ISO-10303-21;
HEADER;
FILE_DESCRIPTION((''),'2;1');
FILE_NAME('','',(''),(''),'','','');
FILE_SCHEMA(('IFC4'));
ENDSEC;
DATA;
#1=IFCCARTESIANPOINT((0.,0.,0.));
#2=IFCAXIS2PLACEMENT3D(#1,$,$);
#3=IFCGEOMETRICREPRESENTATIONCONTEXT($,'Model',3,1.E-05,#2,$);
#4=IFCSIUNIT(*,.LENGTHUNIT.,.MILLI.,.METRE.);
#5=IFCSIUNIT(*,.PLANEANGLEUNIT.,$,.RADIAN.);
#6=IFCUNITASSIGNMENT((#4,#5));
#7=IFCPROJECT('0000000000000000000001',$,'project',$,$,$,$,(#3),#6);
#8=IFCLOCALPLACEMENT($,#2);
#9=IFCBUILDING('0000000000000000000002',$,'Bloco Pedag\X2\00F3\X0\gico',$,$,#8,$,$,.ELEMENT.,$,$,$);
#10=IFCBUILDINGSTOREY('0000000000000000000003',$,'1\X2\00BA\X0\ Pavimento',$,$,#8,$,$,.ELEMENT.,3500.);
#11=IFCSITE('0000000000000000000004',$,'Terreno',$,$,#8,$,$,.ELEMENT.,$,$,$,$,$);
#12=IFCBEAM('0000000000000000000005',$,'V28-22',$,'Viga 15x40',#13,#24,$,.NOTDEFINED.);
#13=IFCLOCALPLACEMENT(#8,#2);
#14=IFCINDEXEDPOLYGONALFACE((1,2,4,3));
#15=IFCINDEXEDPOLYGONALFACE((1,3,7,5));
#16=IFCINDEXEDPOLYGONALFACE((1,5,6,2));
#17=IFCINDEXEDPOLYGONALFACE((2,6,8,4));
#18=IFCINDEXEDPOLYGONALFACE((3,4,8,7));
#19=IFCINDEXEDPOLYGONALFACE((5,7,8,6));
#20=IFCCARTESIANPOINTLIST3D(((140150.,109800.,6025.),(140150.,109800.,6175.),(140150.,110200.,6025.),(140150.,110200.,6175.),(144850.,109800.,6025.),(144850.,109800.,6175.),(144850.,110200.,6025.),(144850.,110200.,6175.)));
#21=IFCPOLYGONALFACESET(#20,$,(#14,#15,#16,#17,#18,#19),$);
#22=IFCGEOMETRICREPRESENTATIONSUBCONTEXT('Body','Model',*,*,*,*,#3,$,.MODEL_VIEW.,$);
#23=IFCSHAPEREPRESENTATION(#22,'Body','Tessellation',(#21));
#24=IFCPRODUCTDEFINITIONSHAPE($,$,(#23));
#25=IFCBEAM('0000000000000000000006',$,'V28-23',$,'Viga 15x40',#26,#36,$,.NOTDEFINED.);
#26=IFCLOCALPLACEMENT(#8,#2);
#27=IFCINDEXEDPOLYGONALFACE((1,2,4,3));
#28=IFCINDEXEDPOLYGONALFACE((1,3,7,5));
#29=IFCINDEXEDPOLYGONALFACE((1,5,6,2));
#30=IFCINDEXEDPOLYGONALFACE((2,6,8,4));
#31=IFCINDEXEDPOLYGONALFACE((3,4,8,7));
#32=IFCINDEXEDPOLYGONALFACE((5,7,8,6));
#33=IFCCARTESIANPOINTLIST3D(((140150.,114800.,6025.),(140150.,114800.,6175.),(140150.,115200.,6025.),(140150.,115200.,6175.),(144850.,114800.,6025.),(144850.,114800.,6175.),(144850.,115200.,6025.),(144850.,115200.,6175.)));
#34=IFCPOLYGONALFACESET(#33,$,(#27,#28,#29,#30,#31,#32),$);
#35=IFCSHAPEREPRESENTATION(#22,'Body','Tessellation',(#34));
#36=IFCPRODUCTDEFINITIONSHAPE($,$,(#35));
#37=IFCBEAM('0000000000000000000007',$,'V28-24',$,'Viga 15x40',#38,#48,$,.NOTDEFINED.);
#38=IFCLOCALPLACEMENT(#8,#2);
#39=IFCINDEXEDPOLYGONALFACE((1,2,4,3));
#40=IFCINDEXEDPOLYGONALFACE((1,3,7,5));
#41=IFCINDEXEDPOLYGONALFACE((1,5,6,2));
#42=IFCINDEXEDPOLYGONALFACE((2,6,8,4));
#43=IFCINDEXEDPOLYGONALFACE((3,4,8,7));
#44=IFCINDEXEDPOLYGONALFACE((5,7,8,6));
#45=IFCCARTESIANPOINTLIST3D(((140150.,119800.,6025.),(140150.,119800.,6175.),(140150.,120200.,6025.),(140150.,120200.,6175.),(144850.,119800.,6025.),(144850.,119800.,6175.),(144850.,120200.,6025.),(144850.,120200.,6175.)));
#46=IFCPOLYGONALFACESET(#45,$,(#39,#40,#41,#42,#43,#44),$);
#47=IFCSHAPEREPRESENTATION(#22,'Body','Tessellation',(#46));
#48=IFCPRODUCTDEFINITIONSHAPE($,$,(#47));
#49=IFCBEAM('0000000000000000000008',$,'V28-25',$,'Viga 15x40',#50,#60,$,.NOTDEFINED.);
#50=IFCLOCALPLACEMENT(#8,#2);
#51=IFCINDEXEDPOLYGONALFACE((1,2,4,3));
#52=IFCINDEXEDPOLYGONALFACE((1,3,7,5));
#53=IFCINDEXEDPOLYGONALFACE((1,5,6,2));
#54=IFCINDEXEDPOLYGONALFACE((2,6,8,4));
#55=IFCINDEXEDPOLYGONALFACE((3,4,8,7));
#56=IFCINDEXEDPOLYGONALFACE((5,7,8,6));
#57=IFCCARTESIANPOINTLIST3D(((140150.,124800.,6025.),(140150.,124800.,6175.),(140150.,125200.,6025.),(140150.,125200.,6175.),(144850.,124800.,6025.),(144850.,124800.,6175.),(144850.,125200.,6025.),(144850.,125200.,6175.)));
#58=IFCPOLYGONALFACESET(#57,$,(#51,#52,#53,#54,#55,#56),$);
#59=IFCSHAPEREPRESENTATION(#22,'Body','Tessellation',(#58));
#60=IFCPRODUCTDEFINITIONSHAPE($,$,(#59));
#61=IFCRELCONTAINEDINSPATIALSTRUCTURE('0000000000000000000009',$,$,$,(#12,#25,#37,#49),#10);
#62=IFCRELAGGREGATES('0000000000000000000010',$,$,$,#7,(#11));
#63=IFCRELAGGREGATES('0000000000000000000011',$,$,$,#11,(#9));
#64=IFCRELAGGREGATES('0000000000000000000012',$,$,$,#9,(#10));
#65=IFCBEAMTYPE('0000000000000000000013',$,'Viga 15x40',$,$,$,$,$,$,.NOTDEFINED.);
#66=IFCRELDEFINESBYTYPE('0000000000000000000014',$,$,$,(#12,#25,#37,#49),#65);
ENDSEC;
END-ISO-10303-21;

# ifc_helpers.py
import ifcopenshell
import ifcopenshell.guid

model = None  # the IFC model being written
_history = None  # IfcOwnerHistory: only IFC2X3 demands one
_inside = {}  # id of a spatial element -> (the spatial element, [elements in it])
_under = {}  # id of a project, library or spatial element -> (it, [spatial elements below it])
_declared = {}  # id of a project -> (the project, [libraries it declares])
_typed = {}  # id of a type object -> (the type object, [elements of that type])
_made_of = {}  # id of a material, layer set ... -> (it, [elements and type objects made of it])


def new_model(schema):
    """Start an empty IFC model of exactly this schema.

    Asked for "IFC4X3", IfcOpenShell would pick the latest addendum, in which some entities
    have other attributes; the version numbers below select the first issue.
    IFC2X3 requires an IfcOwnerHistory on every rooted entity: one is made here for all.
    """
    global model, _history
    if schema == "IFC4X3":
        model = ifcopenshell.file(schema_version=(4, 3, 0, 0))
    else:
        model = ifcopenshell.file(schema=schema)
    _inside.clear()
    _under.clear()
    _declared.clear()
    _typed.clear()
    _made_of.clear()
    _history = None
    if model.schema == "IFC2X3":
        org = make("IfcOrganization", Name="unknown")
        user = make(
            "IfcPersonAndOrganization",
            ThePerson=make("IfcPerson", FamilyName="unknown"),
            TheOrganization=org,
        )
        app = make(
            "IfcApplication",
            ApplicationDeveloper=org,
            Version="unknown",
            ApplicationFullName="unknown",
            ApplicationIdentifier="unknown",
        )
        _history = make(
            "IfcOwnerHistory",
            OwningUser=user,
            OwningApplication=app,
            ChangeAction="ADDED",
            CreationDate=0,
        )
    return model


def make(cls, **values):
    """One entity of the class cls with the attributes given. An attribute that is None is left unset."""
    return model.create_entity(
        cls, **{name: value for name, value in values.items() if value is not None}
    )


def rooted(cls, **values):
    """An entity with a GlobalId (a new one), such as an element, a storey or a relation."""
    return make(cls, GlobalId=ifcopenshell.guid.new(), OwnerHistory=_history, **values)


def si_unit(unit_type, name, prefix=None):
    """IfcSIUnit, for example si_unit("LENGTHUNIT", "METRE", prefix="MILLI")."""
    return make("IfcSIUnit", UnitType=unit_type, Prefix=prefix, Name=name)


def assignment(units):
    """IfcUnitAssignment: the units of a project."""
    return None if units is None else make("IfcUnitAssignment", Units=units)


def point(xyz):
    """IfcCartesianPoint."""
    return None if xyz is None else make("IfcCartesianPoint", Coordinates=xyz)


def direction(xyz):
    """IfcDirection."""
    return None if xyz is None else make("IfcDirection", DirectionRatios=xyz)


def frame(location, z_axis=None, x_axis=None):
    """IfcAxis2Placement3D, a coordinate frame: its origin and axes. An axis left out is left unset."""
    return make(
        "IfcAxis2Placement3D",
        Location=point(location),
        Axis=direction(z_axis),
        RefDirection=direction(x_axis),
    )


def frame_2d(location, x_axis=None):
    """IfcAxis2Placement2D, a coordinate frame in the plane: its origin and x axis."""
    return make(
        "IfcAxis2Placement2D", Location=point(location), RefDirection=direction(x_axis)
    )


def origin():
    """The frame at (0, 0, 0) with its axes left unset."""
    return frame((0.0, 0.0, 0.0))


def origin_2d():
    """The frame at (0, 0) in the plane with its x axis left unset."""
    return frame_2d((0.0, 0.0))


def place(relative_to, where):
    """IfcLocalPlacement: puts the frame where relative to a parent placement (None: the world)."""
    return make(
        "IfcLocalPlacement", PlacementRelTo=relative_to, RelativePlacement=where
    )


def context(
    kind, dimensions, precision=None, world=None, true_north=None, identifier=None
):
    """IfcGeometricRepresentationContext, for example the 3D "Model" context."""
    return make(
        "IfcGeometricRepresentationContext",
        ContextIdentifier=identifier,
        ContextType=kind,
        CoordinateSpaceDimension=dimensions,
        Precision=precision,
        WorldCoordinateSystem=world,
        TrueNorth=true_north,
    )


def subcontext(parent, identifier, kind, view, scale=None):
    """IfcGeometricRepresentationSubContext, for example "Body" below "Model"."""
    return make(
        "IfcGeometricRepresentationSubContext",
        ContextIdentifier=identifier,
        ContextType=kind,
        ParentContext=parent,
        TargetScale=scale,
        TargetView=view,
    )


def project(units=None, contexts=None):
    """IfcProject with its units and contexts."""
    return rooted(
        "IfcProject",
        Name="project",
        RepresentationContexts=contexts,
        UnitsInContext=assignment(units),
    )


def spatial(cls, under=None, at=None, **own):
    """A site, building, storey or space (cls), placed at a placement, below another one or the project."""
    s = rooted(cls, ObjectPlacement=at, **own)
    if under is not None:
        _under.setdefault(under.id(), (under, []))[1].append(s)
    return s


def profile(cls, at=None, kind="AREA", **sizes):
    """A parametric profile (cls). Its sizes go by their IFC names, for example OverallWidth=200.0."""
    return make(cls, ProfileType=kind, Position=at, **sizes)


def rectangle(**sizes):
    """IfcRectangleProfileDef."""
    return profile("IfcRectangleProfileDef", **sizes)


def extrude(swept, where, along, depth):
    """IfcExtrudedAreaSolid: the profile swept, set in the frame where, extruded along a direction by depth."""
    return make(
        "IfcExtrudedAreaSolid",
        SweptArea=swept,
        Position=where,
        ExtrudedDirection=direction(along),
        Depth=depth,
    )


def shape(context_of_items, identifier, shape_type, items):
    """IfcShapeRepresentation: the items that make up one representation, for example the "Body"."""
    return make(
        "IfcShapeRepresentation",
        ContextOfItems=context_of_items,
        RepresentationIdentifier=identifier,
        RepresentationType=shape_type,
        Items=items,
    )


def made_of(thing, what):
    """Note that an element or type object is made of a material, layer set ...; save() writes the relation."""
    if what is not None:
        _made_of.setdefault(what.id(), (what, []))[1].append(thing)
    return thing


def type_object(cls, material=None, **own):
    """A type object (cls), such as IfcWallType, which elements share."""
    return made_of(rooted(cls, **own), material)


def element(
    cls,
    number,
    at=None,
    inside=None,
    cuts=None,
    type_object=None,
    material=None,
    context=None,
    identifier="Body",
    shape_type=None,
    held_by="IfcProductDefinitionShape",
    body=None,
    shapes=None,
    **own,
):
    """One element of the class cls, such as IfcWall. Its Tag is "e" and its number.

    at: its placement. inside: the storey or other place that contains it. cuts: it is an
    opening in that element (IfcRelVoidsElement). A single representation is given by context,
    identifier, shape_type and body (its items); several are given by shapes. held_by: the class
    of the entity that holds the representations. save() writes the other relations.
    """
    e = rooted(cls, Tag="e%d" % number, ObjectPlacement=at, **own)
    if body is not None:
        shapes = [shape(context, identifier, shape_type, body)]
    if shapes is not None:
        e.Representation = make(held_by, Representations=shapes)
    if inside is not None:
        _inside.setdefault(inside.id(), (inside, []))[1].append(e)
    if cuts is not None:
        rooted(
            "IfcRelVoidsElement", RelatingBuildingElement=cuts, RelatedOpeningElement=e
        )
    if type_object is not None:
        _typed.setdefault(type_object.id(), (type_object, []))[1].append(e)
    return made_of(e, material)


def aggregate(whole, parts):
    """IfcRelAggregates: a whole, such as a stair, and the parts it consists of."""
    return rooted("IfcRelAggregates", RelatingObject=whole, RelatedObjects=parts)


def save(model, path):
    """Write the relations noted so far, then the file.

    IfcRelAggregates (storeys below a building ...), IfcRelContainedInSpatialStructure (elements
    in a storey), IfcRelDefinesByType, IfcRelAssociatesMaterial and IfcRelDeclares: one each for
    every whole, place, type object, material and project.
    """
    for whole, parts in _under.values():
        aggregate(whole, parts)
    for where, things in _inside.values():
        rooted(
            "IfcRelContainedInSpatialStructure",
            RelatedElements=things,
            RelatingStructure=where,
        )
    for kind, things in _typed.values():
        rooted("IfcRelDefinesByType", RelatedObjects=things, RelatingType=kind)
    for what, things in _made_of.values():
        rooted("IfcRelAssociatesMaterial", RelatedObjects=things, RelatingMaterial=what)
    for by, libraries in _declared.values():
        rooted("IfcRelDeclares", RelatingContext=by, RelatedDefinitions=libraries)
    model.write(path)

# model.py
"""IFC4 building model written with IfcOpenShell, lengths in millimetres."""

from ifc_helpers import new_model, si_unit, frame, origin, origin_2d, place, context, subcontext, project, spatial, rectangle, extrude, type_object, element, save


model = new_model("IFC4")

# Units and contexts
model_context = context("Model", 3, precision=1e-05, world=origin())
body_context = subcontext(model_context, "Body", "Model", "MODEL_VIEW")
ifc_project = project(units=[si_unit("LENGTHUNIT", "METRE", prefix="MILLI"), si_unit("PLANEANGLEUNIT", "RADIAN")], contexts=[model_context])

# Site, building, storey
placement = place(None, origin())
site = spatial("IfcSite", under=ifc_project, at=placement, Name="Terreno", CompositionType="ELEMENT")
building = spatial("IfcBuilding", under=site, at=placement, Name="Bloco Pedagógico", CompositionType="ELEMENT")
storey = spatial("IfcBuildingStorey", under=building, at=placement, Name="1º Pavimento", CompositionType="ELEMENT", Elevation=3500.0)

# Beams
beam_type = type_object("IfcBeamType", Name="Viga 15x40", PredefinedType="NOTDEFINED")
for number, where, z_axis, x_axis, name in (
    (1, (140150.0, 110000.0, 6100.0), (1.0, 0.0, 0.0), (0.0, 1.0, 0.0), "V28-22"),
    (2, (140150.0, 115000.0, 6100.0), (1.0, 0.0, 0.0), (0.0, 1.0, 0.0), "V28-23"),
    (3, (140150.0, 120000.0, 6100.0), (1.0, 0.0, 0.0), (0.0, 1.0, 0.0), "V28-24"),
    (4, (140150.0, 125000.0, 6100.0), (1.0, 0.0, 0.0), (0.0, 1.0, 0.0), "V28-25"),
):
    element("IfcBeam", number, at=place(None, frame(where, z_axis=z_axis, x_axis=x_axis)), inside=storey, type_object=beam_type, Name=name, ObjectType="Viga 15x40", PredefinedType="NOTDEFINED", context=body_context, shape_type="SweptSolid", body=[
        extrude(rectangle(XDim=400.0, YDim=150.0, at=origin_2d()), None, (0.0, 0.0, 1.0), 4700.0),
    ])

save(model, "model.ifc")
